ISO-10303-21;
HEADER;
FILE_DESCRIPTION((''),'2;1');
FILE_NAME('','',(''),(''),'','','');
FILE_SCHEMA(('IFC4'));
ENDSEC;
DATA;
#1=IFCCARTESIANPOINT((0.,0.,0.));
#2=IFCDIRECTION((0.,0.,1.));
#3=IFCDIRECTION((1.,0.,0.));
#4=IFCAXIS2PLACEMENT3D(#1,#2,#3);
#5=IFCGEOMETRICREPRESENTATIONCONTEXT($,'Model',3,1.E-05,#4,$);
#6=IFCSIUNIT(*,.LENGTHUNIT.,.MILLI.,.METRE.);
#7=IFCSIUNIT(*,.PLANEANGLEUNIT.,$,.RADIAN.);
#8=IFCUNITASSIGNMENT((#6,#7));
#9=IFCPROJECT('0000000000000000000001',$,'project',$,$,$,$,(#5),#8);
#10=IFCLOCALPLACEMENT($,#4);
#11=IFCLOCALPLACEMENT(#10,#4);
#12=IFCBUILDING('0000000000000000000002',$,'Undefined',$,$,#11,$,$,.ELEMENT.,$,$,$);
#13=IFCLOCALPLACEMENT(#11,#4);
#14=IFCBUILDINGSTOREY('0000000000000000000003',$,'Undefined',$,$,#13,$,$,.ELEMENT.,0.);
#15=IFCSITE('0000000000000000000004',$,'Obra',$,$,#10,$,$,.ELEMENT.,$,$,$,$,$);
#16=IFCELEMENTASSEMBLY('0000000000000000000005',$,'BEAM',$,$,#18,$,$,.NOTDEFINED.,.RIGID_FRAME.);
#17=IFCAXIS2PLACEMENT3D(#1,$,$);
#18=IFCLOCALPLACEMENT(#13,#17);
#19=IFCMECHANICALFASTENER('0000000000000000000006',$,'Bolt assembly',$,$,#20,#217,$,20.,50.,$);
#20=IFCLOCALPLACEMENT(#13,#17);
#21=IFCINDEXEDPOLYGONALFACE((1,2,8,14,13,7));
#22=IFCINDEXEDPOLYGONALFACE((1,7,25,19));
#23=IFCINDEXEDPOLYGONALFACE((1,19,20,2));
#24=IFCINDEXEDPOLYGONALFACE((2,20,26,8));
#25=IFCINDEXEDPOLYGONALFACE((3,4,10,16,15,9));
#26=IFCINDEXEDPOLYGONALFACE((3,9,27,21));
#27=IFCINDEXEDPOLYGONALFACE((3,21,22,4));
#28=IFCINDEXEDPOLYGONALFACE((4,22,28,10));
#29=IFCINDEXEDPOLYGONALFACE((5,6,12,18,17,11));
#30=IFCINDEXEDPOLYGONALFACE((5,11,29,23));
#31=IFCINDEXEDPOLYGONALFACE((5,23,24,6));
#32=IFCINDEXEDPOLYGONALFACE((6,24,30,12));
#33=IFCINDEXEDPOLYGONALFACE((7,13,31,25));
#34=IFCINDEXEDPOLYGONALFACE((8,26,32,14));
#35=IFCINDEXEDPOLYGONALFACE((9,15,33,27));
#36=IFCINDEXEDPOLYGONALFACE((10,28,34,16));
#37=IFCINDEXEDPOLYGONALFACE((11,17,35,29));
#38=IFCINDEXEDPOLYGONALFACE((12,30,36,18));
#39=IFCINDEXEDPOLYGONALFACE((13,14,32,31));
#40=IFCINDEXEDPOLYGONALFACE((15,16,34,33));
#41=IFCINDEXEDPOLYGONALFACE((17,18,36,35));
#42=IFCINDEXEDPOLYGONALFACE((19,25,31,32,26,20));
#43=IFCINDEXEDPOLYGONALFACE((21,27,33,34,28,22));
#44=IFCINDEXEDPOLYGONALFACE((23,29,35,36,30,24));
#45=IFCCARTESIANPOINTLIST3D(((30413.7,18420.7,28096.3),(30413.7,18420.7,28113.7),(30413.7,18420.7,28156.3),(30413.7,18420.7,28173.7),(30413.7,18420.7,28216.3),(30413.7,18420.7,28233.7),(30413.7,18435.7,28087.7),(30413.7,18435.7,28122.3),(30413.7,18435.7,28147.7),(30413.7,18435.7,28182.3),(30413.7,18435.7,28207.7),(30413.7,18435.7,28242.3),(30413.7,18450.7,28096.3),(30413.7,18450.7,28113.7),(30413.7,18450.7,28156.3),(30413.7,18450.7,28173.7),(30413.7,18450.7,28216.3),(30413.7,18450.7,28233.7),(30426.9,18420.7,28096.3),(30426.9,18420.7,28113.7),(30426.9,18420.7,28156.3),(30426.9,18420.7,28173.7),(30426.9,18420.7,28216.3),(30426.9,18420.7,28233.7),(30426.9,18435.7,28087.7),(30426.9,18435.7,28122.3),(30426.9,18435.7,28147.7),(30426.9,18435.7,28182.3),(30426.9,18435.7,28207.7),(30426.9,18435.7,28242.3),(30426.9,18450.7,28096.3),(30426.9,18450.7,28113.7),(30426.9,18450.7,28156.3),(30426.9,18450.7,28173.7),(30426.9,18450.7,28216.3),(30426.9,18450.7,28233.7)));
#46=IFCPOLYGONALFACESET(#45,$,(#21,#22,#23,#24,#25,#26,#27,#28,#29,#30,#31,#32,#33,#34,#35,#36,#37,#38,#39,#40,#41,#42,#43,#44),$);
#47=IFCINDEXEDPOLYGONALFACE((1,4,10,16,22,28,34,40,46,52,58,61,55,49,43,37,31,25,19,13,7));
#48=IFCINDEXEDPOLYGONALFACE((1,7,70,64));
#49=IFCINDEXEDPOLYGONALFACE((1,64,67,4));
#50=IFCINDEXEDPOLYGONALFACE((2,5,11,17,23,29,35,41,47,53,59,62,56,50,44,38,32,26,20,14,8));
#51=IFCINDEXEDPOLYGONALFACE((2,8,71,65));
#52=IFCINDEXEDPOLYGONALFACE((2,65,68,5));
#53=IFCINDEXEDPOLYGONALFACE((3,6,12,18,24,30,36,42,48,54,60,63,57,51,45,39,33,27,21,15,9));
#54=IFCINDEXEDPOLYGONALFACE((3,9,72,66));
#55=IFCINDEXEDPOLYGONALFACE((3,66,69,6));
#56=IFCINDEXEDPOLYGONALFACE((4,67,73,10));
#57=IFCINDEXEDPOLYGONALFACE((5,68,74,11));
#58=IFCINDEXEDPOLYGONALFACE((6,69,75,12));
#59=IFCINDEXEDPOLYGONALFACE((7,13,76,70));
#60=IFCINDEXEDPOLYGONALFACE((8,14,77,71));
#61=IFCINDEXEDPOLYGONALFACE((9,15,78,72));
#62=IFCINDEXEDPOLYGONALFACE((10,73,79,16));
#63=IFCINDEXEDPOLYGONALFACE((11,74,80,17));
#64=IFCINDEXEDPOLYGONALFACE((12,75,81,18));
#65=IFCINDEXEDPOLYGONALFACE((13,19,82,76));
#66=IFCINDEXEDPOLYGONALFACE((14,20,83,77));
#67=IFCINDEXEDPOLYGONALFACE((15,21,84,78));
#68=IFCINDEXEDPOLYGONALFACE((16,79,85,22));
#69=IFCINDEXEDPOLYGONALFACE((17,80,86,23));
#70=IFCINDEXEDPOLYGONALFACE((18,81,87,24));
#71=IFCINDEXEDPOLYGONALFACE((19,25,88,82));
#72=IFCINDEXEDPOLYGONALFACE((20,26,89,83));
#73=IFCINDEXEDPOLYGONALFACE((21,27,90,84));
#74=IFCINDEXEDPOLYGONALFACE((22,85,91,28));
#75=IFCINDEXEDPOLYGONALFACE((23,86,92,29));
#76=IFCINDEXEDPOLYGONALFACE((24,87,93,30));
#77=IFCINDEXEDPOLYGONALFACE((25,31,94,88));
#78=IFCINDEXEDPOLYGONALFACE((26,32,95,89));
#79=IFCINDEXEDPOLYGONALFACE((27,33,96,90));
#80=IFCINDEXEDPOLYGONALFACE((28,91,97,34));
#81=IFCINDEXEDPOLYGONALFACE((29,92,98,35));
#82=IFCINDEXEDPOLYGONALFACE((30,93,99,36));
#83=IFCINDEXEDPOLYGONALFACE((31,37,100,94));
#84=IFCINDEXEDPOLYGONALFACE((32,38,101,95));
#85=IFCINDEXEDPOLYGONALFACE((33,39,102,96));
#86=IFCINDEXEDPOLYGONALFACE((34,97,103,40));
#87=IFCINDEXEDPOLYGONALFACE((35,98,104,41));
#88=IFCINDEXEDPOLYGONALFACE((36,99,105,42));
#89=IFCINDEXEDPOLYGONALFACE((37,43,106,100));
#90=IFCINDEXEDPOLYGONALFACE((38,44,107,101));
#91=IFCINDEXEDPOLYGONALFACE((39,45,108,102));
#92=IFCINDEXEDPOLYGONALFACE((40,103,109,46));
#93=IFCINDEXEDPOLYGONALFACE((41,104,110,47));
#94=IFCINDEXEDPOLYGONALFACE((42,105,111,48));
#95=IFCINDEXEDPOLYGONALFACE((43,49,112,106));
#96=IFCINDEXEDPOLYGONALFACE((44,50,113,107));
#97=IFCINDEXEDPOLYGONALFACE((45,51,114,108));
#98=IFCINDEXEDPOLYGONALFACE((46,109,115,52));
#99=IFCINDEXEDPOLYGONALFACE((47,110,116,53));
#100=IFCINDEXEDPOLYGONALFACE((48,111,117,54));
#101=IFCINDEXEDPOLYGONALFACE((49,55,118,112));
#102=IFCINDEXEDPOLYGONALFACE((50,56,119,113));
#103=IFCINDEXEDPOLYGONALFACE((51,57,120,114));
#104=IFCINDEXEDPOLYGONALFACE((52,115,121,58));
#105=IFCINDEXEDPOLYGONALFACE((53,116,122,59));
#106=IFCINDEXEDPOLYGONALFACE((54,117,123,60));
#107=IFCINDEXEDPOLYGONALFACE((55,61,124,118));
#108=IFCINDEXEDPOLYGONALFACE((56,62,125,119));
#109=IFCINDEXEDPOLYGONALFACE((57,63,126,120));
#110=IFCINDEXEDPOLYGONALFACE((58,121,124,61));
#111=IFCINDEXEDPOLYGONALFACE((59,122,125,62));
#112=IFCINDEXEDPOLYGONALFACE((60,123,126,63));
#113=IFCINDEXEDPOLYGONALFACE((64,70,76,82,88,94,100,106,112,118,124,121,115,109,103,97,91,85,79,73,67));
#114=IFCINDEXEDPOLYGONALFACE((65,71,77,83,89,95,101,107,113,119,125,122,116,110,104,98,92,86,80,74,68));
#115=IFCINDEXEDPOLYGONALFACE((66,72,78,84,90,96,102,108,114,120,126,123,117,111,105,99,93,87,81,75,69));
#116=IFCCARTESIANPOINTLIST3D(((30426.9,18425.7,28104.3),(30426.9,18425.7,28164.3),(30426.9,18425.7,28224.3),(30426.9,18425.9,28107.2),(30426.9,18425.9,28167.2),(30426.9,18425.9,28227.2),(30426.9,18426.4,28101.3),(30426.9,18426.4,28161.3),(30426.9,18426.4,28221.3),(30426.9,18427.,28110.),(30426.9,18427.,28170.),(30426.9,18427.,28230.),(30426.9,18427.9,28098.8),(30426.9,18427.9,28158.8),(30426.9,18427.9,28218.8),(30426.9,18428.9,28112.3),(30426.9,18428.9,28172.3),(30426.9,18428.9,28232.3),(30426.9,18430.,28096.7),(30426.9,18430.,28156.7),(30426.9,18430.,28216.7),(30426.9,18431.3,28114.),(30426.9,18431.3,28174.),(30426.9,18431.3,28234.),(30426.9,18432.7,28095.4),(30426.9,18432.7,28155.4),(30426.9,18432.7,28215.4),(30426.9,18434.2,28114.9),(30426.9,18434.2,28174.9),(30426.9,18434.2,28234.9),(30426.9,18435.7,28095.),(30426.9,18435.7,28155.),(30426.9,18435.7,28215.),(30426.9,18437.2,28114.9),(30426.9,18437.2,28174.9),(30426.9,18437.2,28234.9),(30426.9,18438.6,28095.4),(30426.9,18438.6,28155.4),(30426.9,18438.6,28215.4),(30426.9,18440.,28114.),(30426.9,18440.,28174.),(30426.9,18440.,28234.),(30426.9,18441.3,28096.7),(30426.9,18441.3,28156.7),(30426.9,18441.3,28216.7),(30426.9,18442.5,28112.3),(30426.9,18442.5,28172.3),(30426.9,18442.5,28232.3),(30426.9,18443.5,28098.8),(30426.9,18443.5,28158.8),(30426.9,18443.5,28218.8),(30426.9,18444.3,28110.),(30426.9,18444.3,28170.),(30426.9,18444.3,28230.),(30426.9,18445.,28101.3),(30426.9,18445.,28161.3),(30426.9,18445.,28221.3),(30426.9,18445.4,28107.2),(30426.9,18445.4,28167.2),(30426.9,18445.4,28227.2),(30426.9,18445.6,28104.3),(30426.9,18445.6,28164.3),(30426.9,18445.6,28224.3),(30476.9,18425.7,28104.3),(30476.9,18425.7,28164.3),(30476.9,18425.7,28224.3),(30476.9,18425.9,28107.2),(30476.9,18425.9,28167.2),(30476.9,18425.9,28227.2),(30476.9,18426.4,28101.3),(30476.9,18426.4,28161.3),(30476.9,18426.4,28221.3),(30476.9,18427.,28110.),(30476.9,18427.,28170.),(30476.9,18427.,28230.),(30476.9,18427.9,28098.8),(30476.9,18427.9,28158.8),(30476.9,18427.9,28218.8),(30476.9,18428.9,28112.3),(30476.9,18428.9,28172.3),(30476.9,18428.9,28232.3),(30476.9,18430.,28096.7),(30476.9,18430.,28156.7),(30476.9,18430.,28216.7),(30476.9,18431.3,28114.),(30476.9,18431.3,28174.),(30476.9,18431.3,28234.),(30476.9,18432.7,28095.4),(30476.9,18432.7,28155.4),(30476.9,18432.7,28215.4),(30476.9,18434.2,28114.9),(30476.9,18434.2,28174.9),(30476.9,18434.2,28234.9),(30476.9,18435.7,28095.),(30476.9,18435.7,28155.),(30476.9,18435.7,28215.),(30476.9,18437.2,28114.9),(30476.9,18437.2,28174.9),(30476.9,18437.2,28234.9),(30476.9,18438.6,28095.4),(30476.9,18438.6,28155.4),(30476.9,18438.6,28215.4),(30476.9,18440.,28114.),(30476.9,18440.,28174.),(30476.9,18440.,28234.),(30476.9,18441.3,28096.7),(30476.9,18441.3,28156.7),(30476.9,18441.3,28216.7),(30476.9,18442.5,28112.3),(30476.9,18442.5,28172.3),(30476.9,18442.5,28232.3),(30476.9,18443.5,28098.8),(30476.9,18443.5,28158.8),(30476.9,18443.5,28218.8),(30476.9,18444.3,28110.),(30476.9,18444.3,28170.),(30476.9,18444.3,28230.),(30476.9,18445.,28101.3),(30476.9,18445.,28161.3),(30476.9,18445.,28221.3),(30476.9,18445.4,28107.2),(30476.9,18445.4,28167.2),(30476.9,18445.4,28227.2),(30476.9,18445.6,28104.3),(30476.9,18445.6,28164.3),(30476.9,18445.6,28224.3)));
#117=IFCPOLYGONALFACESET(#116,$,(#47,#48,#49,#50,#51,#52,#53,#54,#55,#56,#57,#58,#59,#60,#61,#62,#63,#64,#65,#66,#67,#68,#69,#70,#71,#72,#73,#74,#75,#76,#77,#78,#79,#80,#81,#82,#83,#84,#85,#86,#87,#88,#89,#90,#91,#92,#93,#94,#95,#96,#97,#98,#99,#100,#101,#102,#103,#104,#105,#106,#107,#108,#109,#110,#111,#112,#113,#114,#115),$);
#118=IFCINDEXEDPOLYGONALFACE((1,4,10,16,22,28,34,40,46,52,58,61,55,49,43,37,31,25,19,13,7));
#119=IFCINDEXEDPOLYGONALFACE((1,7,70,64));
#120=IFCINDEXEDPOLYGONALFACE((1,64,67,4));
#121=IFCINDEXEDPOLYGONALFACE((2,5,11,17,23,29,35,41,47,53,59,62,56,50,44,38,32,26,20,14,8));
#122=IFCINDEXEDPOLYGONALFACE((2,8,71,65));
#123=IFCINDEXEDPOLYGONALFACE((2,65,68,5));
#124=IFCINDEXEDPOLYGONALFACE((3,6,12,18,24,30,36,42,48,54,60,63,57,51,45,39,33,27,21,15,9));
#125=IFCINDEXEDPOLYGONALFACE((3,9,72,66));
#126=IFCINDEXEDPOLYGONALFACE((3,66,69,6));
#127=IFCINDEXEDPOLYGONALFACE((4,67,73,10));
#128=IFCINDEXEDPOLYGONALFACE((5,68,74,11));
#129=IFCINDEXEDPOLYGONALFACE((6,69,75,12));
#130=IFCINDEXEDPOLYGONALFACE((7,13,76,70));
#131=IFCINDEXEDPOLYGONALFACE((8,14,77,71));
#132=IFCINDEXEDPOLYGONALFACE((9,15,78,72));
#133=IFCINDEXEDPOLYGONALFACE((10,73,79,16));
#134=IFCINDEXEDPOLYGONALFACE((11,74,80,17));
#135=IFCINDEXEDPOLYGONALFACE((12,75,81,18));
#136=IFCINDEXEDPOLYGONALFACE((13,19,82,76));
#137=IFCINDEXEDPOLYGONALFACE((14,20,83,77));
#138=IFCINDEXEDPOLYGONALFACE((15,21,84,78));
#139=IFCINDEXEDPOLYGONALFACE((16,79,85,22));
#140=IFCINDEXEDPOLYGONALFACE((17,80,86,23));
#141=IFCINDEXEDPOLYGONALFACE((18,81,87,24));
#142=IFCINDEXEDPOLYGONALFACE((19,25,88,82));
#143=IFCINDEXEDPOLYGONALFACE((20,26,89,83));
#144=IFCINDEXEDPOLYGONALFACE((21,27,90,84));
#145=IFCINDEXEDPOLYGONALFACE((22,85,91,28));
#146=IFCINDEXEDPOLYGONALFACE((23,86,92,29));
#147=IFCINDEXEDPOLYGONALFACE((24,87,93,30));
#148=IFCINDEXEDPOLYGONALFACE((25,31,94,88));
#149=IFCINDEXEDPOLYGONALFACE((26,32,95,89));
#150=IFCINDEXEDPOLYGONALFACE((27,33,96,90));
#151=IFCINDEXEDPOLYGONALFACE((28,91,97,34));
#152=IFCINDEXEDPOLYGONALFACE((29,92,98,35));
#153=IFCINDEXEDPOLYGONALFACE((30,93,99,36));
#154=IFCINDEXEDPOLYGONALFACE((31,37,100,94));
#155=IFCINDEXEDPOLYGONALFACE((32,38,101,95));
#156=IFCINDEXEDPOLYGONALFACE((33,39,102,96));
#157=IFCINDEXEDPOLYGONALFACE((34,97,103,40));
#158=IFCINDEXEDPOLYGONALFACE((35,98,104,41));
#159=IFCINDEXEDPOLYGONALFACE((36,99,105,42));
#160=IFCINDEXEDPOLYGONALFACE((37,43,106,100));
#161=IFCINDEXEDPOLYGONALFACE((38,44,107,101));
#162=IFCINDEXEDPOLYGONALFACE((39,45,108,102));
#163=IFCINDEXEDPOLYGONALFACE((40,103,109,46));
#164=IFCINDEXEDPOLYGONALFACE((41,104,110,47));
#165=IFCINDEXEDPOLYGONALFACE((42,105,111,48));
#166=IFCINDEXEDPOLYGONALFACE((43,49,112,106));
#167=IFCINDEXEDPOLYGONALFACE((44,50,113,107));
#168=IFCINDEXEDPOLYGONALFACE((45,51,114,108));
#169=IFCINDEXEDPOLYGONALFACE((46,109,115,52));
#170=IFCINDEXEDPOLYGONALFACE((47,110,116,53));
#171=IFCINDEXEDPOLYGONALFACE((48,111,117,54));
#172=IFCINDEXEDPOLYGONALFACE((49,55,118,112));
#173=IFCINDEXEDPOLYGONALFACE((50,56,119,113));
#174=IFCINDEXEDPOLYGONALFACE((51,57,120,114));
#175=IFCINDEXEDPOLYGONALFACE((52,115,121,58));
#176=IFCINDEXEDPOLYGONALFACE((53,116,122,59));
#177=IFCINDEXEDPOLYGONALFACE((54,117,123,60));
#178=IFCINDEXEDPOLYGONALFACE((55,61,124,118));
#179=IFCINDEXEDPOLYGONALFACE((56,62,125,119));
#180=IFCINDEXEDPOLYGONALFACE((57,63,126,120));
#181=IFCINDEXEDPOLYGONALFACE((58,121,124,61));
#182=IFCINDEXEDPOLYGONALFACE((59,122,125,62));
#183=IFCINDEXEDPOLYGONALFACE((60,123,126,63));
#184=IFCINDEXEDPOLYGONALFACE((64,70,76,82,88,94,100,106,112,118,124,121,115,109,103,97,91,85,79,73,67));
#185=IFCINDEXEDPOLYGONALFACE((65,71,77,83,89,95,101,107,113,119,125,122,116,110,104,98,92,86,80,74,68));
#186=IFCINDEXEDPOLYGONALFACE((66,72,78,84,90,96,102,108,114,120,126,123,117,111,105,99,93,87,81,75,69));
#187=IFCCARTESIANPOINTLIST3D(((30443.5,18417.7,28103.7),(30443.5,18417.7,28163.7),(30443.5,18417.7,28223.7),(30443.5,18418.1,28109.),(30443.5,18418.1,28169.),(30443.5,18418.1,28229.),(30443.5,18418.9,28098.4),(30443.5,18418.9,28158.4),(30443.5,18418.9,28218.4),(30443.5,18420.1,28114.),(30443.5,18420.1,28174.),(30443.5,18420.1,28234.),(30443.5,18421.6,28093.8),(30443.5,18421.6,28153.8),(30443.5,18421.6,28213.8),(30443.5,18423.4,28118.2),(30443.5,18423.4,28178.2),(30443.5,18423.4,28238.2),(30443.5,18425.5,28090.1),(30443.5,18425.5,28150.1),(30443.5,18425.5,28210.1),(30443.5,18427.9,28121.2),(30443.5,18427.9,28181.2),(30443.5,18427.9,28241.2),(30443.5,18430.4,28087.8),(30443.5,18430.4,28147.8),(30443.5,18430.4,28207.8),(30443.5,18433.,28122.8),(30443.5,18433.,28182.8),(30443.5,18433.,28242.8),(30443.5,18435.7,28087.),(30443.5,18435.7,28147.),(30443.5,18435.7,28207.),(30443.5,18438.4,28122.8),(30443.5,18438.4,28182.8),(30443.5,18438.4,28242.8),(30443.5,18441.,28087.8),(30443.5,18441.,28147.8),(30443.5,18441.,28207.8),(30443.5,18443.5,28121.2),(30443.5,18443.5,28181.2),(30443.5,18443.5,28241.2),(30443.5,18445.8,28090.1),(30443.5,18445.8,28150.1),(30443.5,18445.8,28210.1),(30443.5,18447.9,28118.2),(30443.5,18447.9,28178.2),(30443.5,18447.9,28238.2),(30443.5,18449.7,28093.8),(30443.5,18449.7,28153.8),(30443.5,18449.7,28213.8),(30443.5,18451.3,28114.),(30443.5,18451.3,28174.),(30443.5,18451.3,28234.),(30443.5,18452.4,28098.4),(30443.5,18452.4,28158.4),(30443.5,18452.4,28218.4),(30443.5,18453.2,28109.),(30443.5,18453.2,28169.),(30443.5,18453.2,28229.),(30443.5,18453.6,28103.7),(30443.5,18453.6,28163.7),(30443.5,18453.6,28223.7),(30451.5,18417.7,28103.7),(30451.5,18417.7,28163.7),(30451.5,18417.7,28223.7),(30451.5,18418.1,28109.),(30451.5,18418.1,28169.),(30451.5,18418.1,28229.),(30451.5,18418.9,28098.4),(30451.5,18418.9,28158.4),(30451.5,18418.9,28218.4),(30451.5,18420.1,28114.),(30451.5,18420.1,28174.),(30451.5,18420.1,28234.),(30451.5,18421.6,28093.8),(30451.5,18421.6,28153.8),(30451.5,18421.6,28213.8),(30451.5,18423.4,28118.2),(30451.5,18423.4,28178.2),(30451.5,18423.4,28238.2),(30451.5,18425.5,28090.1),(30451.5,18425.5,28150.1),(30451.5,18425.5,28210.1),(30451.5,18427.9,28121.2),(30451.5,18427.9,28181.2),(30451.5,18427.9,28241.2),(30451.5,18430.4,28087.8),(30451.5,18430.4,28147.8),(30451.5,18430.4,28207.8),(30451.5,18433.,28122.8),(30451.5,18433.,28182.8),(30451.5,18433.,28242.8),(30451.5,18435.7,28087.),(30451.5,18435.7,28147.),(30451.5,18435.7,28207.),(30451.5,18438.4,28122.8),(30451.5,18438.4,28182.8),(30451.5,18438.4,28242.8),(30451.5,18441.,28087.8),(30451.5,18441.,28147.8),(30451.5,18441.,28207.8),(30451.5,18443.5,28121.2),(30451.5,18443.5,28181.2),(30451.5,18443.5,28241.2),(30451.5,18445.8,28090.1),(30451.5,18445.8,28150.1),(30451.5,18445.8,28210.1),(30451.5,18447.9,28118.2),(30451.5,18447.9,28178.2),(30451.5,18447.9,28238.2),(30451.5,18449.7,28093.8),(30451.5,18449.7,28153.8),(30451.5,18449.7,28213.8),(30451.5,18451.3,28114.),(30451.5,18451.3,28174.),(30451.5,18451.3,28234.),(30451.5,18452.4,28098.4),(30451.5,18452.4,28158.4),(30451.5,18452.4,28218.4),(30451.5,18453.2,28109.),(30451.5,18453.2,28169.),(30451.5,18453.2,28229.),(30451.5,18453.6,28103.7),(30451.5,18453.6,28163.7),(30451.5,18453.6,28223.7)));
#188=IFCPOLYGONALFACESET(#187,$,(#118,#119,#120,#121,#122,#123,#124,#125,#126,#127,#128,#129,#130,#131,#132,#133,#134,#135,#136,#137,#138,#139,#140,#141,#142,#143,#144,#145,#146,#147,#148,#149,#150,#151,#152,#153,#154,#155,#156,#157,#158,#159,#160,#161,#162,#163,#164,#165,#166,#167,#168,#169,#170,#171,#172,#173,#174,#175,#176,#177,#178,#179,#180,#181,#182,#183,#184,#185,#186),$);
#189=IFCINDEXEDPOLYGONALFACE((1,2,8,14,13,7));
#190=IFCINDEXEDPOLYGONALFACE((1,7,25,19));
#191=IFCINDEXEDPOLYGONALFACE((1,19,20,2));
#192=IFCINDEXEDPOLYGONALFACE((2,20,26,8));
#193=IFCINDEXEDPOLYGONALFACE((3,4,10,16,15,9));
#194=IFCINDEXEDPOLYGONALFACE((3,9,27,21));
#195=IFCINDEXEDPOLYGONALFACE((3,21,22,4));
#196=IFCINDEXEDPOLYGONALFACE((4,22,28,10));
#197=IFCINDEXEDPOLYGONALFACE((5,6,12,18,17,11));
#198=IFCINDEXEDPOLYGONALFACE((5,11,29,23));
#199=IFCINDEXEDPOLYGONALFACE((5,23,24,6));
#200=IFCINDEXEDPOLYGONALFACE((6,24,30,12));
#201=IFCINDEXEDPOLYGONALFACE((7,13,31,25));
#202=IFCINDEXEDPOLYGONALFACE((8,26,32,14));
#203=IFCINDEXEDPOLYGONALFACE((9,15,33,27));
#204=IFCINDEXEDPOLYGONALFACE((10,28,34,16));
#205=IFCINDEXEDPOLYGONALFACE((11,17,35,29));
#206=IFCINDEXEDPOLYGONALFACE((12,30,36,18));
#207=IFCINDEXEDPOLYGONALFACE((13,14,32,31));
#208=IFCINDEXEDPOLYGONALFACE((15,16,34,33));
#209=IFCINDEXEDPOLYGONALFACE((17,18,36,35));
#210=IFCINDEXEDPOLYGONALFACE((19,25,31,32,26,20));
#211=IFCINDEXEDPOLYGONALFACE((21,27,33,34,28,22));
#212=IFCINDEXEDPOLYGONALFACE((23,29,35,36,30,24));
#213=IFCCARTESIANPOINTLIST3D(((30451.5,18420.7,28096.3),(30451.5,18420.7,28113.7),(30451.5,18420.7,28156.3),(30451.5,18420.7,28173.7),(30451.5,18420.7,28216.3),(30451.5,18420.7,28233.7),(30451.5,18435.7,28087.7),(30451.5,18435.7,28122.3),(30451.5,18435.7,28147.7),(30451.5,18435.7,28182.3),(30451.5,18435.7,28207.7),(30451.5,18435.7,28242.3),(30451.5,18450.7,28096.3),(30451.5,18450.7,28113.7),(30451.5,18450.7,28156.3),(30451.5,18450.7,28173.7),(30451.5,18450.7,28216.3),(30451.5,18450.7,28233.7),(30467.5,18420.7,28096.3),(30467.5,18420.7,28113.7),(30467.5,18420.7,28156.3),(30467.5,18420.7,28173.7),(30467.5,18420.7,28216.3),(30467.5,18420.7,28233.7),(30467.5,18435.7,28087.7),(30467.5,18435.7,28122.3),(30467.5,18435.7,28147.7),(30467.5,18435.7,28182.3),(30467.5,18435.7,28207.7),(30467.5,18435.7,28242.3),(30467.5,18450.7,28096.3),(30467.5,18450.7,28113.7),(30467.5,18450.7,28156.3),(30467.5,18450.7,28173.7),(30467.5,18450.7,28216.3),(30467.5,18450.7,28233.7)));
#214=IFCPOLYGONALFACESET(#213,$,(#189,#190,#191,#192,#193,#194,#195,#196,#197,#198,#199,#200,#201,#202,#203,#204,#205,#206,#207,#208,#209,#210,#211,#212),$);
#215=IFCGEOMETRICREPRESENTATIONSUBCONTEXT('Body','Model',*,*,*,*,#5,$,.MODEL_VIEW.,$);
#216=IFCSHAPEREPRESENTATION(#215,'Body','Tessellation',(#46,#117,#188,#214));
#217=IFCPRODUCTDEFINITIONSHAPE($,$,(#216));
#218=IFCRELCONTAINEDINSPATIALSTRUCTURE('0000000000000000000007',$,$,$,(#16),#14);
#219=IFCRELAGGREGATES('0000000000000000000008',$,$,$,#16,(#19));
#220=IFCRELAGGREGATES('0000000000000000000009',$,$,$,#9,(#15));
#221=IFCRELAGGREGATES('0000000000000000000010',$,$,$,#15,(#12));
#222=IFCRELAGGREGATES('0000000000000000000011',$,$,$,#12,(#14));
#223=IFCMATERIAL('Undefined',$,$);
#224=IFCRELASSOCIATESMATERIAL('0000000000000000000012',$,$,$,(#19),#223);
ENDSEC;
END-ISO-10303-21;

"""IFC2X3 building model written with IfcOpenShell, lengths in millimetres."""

from ifc_helpers import new_model, si_unit, frame, origin_with_axes, origin_2d_with_axis, place, context, subcontext, project, spatial, polyline, circle, outline, extrude, source, transform, mapped, material, element, aggregate, save


model = new_model("IFC2X3")

# Units and contexts
model_context = context("Model", 3, precision=1e-05, world=origin_with_axes())
body_context = subcontext(model_context, "Body", "Model", "MODEL_VIEW")
ifc_project = project(units=[si_unit("LENGTHUNIT", "METRE", prefix="MILLI"), si_unit("PLANEANGLEUNIT", "RADIAN")], contexts=[model_context])

# Site, building, storey
site_placement = place(None, origin_with_axes())
site = spatial("IfcSite", under=ifc_project, at=site_placement, Name="Obra", CompositionType="ELEMENT")
building_placement = place(site_placement, origin_with_axes())
building = spatial("IfcBuilding", under=site, at=building_placement, Name="Undefined", CompositionType="ELEMENT")
storey_placement = place(building_placement, origin_with_axes())
storey = spatial("IfcBuildingStorey", under=building, at=storey_placement, Name="Undefined", CompositionType="ELEMENT", Elevation=0.0)

# Element assembly, mechanical fastener
ifc_material_1 = material(Name="Undefined")
assembly_1_placement = place(storey_placement, origin_with_axes())
assembly_1 = element("IfcElementAssembly", 1, at=assembly_1_placement, inside=storey, Name="BEAM", AssemblyPlace="NOTDEFINED", PredefinedType="RIGID_FRAME")
shared_shape_1 = source(origin_with_axes(), body_context, "Body", "SweptSolid", [
    extrude(outline(polyline([(17.3, 0.0), (8.7, 15.0), (-8.7, 15.0), (-17.3, 0.0), (-8.7, -15.0), (8.7, -15.0), (17.3, 0.0)])), frame((0.0, -26.5, 0.0), z_axis=(0.0, 1.0, 0.0), x_axis=(1.0, 0.0, 0.0)), (0.0, 0.0, 1.0), 13.2),
    extrude(circle(Radius=10.0, at=origin_2d_with_axis()), frame((0.0, -13.3, 0.0), z_axis=(0.0, 1.0, 0.0), x_axis=(1.0, 0.0, 0.0)), (0.0, 0.0, 1.0), 50.0),
    extrude(circle(Radius=18.0, at=origin_2d_with_axis()), frame((0.0, 3.3, 0.0), z_axis=(0.0, 1.0, 0.0), x_axis=(1.0, 0.0, 0.0)), (0.0, 0.0, 1.0), 8.0),
    extrude(outline(polyline([(17.3, 0.0), (8.7, 15.0), (-8.7, 15.0), (-17.3, 0.0), (-8.7, -15.0), (8.7, -15.0), (17.3, 0.0)])), frame((0.0, 11.3, 0.0), z_axis=(0.0, 1.0, 0.0), x_axis=(1.0, 0.0, 0.0)), (0.0, 0.0, 1.0), 16.0),
])
mechanical_fastener_1_placement = place(assembly_1_placement, frame((30440.2, 18485.7, 28265.0), z_axis=(0.0, -1.0, 0.0), x_axis=(0.0, 0.0, -1.0)))
mechanical_fastener_1 = element("IfcMechanicalFastener", 2, at=mechanical_fastener_1_placement, material=ifc_material_1, Name="Bolt assembly", NominalDiameter=20.0, NominalLength=50.0, context=body_context, shape_type="MappedRepresentation", body=[
    mapped(shared_shape_1, transform((40.0, 0.0, 50.0))),
    mapped(shared_shape_1, transform((100.0, 0.0, 50.0))),
    mapped(shared_shape_1, transform((160.0, 0.0, 50.0))),
])
aggregate(assembly_1, [mechanical_fastener_1])

save(model, "model.ifc")
